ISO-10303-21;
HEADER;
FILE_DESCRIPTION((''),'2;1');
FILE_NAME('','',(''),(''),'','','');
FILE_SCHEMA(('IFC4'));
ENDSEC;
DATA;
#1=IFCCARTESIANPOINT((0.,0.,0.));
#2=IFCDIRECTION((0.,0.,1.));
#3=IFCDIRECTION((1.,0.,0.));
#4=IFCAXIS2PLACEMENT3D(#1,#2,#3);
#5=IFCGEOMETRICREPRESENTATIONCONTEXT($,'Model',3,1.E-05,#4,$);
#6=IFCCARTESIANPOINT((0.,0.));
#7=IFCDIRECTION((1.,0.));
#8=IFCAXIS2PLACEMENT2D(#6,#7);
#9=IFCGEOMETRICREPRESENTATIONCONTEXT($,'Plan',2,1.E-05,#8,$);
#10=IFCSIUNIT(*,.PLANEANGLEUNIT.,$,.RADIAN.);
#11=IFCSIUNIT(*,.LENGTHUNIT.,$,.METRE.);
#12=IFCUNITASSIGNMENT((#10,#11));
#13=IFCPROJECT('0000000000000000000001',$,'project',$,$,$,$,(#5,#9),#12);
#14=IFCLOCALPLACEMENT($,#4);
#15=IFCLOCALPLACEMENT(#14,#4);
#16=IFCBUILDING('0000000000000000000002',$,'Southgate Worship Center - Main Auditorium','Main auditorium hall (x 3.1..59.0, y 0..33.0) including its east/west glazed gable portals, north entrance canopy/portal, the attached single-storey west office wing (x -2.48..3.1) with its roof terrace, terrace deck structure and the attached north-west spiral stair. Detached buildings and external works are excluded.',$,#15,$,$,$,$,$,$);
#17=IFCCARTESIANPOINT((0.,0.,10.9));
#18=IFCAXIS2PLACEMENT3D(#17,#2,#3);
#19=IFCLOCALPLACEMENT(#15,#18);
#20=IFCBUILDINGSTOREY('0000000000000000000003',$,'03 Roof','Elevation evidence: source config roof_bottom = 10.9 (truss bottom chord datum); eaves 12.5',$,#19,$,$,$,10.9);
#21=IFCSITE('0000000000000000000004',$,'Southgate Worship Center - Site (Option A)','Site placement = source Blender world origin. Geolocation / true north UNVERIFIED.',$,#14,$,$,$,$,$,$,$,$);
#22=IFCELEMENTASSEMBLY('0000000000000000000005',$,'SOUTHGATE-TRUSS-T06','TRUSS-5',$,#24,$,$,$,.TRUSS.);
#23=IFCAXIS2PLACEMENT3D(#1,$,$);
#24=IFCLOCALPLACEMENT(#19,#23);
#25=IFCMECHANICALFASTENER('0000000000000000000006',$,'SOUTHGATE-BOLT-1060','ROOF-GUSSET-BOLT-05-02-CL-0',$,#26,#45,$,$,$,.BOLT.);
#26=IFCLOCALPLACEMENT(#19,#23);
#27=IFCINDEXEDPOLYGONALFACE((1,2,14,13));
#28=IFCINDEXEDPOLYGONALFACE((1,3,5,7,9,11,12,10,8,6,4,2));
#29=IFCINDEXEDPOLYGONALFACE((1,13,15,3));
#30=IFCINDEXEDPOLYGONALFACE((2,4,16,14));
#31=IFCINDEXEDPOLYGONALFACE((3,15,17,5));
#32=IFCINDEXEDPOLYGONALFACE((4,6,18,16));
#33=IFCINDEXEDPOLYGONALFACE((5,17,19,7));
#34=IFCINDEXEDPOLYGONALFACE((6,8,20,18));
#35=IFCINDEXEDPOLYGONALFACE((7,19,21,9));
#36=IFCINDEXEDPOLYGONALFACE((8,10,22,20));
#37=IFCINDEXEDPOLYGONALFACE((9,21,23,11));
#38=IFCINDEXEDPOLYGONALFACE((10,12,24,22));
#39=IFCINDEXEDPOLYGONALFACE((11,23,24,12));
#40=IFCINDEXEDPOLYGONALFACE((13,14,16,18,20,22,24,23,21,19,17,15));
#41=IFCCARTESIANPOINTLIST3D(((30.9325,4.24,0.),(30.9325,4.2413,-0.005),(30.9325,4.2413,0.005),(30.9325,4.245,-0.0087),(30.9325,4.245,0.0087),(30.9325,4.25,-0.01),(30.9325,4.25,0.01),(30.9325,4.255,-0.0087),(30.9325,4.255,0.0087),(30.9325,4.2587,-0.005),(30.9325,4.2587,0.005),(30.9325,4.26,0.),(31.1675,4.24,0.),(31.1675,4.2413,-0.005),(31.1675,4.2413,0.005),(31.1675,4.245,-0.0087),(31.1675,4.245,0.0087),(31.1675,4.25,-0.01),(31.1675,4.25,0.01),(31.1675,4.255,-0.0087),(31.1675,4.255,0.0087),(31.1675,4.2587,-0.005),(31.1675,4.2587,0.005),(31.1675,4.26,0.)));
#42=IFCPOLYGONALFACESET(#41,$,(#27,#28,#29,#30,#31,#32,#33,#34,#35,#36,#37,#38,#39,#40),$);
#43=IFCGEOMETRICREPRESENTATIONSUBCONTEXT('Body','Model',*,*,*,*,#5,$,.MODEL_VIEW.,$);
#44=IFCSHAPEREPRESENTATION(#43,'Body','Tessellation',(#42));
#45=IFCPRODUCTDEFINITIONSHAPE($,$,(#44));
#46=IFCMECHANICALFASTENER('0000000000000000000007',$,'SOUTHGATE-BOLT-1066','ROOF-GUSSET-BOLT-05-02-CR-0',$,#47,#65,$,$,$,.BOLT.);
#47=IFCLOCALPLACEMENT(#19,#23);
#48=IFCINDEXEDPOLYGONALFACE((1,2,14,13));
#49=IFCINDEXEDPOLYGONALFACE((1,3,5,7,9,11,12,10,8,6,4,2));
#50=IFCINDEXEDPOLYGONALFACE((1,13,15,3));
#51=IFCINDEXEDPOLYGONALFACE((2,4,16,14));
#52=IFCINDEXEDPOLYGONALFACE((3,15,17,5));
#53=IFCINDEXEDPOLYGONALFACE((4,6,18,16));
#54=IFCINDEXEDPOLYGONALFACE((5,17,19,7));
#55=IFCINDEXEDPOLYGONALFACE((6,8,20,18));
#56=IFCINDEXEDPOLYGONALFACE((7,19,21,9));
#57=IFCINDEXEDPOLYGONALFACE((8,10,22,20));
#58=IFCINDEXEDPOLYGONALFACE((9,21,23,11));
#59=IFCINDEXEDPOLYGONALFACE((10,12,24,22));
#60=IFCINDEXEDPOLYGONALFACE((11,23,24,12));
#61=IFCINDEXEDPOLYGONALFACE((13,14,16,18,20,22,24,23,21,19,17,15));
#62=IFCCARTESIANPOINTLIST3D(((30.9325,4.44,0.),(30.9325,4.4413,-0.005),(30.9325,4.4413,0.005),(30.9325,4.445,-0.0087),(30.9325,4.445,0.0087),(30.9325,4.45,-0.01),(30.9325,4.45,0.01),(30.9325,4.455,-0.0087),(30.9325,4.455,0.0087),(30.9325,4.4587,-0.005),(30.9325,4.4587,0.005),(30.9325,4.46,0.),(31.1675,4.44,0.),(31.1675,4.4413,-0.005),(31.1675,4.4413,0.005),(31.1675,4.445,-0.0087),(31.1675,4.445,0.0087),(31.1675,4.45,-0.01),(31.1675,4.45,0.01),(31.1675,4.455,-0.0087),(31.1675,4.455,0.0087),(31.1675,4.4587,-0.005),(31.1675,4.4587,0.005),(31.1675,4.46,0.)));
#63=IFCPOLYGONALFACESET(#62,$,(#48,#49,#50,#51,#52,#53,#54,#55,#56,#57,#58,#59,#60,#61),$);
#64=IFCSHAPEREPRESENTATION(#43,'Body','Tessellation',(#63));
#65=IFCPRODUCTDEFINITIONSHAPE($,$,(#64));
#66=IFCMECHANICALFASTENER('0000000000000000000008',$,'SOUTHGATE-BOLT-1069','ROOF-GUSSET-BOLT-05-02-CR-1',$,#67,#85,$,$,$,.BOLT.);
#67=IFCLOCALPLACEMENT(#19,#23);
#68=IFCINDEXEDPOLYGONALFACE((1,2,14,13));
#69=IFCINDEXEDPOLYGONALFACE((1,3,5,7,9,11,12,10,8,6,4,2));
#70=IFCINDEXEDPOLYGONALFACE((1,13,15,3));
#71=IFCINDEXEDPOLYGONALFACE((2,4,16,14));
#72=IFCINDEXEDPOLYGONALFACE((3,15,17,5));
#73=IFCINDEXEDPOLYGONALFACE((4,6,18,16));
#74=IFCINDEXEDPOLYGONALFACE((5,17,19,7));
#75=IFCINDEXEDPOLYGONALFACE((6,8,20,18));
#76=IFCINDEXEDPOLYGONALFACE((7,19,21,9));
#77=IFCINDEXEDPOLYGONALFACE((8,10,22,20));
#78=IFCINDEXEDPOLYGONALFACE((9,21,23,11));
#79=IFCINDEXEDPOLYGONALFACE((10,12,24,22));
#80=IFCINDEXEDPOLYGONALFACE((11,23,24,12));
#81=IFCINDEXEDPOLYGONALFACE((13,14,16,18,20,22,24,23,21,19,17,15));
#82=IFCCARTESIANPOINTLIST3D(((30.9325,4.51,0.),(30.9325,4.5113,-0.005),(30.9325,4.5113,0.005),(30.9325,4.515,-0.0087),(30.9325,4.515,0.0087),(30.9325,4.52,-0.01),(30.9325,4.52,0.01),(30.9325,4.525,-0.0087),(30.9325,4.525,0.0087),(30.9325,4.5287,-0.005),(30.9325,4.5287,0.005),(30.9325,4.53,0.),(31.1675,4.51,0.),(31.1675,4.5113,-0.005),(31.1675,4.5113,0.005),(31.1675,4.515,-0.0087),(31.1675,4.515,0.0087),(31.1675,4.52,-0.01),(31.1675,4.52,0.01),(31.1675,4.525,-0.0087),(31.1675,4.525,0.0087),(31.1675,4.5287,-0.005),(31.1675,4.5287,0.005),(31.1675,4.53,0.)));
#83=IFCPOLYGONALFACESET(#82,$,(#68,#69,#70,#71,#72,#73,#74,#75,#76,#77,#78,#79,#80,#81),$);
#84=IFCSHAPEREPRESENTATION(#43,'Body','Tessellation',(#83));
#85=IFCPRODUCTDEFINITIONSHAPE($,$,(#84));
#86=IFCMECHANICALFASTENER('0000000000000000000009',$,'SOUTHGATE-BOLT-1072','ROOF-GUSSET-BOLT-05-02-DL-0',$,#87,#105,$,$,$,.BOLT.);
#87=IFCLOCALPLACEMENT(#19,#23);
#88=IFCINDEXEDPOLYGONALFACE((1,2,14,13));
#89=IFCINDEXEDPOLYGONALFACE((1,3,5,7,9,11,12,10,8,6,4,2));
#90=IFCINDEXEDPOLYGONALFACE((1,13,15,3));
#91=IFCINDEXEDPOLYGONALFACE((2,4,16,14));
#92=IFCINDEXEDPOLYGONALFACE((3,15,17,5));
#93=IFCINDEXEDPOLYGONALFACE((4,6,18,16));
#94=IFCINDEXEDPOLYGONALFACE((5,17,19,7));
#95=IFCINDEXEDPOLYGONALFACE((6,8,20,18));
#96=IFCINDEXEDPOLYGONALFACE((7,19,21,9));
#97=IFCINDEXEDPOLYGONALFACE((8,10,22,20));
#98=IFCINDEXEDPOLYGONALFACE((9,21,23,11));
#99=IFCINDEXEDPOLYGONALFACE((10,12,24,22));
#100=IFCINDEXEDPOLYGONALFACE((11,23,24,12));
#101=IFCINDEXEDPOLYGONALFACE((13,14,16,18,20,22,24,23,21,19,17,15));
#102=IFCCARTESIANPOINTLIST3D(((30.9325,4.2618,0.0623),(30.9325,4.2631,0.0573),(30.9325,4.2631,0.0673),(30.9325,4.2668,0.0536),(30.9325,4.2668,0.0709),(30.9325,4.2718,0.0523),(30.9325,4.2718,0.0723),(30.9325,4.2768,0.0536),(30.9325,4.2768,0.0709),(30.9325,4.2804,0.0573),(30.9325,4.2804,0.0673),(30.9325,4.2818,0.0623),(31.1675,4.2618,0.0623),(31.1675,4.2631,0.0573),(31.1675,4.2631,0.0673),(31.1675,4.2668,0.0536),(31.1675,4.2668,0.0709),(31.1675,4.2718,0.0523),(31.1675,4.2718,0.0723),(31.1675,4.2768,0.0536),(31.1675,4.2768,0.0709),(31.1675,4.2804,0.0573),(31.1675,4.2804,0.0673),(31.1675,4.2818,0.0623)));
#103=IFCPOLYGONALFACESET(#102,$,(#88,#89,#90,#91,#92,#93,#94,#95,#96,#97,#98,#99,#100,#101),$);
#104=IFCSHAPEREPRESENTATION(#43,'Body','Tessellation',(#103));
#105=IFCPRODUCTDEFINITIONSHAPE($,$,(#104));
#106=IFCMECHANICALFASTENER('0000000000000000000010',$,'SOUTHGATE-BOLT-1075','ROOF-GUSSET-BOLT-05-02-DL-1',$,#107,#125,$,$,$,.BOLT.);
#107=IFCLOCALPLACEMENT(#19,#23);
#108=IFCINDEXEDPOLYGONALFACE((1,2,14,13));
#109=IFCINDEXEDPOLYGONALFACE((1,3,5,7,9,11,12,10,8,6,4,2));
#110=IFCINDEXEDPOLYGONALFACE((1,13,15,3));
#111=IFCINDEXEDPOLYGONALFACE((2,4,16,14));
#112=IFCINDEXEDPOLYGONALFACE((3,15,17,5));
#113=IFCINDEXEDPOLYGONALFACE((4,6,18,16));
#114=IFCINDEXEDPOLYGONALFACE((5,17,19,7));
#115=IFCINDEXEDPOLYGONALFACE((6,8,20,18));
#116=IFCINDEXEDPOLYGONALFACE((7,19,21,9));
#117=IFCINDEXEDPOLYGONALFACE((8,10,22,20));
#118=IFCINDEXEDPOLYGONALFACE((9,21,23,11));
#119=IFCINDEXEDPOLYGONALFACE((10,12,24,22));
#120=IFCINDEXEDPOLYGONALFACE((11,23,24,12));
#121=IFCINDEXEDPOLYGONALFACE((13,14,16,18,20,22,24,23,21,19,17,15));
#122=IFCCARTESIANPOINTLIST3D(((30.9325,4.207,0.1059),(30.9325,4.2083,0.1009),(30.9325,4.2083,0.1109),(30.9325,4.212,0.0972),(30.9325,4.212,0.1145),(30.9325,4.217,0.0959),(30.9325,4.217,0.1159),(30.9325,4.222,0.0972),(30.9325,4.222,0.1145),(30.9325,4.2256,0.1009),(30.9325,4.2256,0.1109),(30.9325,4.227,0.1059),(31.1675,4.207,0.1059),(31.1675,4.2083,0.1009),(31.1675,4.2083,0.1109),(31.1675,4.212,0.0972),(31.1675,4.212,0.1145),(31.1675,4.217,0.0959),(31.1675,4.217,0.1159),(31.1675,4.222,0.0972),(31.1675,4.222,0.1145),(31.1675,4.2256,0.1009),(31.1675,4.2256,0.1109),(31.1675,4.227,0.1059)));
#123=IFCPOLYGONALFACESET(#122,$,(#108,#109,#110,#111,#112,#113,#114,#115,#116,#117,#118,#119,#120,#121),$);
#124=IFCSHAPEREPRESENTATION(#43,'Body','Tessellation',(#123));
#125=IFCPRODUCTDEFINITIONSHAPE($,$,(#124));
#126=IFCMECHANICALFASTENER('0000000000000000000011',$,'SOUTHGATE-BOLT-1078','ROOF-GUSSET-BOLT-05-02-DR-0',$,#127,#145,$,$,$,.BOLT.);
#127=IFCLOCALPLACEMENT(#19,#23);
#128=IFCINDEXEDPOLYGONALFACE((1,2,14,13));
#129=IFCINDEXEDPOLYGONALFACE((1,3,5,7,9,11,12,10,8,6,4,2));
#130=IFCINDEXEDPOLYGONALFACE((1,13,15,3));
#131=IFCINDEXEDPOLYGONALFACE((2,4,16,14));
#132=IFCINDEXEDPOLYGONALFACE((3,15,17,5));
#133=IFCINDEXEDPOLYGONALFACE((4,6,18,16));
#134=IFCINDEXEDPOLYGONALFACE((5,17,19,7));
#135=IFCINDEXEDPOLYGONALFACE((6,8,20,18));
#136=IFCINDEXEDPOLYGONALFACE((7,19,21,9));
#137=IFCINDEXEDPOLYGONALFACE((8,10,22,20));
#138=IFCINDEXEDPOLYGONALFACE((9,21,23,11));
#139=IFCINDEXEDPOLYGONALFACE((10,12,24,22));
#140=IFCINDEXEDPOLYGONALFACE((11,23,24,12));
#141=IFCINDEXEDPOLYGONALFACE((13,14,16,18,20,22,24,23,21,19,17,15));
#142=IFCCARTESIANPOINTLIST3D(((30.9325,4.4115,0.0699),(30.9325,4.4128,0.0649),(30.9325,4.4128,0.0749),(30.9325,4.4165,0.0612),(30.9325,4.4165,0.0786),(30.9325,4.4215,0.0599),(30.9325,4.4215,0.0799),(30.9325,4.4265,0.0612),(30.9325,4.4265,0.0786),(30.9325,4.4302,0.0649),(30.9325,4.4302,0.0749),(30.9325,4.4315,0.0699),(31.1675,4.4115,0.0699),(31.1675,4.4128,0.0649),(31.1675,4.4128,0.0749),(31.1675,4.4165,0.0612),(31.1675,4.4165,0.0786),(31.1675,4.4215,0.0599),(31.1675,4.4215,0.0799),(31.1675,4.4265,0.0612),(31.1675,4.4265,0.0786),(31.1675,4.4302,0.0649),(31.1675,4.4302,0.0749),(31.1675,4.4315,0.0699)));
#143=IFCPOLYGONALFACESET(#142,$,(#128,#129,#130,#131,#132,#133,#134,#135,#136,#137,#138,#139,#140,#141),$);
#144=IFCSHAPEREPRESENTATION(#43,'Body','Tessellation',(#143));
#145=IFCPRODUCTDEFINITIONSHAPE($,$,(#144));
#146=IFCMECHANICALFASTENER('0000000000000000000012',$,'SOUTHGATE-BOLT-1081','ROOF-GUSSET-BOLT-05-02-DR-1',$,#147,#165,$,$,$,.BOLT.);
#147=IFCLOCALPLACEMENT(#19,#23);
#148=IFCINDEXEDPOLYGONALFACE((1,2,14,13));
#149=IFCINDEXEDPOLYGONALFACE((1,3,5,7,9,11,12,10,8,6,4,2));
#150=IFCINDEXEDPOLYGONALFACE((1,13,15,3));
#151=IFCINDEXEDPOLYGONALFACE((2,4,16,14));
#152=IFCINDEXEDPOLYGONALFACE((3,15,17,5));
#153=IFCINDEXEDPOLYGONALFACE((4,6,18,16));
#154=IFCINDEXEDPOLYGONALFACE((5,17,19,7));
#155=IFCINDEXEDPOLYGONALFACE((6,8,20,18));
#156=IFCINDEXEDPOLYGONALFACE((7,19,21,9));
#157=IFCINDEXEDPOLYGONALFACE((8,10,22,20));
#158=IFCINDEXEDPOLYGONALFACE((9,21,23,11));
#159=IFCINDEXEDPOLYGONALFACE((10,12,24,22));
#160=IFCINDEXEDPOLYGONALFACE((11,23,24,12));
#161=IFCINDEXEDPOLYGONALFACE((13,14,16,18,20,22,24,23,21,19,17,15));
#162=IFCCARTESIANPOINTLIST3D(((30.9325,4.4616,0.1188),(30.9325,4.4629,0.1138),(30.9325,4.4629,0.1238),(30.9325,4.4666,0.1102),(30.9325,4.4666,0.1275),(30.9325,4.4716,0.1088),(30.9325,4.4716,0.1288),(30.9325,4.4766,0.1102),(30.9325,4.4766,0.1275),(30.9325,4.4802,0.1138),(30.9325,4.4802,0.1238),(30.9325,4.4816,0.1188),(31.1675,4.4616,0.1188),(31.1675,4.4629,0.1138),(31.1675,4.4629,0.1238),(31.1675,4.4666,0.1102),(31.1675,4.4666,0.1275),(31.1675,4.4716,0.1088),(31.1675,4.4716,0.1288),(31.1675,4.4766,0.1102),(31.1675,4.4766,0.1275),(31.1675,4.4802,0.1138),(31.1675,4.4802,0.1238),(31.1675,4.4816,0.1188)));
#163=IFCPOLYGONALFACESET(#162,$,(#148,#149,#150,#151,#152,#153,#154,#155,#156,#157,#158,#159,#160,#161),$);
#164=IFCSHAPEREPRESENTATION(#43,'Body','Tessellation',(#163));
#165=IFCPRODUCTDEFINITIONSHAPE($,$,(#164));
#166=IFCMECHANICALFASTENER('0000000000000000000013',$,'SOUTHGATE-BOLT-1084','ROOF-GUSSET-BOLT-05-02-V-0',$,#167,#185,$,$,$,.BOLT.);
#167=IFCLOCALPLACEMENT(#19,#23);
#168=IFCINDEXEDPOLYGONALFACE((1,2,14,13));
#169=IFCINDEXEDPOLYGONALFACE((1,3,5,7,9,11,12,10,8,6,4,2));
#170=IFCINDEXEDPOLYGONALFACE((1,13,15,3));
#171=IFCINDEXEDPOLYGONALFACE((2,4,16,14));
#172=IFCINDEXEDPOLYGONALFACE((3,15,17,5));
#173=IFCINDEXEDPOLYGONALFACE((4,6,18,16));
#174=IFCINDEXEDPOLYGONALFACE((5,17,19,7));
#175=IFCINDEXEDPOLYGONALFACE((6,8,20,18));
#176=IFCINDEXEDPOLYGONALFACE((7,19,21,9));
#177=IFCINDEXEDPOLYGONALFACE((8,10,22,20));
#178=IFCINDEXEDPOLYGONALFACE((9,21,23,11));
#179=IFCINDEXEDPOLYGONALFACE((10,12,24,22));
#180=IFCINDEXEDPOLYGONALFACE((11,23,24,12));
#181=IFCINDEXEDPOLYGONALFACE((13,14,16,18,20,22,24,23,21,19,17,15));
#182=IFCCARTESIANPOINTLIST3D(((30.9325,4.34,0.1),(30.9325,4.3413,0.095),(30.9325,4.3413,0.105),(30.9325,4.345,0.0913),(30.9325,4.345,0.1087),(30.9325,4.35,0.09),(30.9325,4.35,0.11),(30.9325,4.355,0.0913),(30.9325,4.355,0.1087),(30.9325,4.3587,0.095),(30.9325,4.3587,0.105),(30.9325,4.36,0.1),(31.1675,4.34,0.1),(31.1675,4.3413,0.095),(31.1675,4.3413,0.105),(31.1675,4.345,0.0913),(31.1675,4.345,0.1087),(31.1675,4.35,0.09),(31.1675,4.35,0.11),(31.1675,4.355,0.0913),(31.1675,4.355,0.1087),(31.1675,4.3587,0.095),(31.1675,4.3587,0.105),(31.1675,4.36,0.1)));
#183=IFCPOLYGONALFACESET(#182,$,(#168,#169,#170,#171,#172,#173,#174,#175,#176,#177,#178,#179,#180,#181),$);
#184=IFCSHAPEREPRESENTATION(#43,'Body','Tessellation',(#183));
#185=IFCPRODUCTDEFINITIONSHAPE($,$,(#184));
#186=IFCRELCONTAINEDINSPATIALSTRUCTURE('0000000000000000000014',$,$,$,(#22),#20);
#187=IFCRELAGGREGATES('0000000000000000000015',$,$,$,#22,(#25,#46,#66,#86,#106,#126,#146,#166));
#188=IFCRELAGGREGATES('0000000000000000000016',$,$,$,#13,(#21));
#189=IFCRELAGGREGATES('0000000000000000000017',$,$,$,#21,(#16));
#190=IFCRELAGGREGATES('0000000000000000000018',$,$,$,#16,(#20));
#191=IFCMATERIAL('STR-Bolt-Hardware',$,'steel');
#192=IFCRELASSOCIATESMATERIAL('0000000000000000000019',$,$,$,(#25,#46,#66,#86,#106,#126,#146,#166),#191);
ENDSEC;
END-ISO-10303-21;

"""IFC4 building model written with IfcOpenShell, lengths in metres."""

from ifc_helpers import new_model, si_unit, frame, origin_with_axes, origin_2d_with_axis, place, context, subcontext, project, spatial, indexed_curve, outline, extrude, material, element, aggregate, save


model = new_model("IFC4")

# Units and contexts
model_context = context("Model", 3, precision=1e-05, world=origin_with_axes())
plan_context = context("Plan", 2, precision=1e-05, world=origin_2d_with_axis())
body_context = subcontext(model_context, "Body", "Model", "MODEL_VIEW")
ifc_project = project(units=[si_unit("PLANEANGLEUNIT", "RADIAN"), si_unit("LENGTHUNIT", "METRE")], contexts=[model_context, plan_context])

# Site, building, storey
site_placement = place(None, origin_with_axes())
site = spatial("IfcSite", under=ifc_project, at=site_placement, Name="Southgate Worship Center - Site (Option A)", Description="Site placement = source Blender world origin. Geolocation / true north UNVERIFIED.")
building_placement = place(site_placement, origin_with_axes())
building = spatial("IfcBuilding", under=site, at=building_placement, Name="Southgate Worship Center - Main Auditorium", Description="Main auditorium hall (x 3.1..59.0, y 0..33.0) including its east/west glazed gable portals, north entrance canopy/portal, the attached single-storey west office wing (x -2.48..3.1) with its roof terrace, terrace deck structure and the attached north-west spiral stair. Detached buildings and external works are excluded.")
storey_placement = place(building_placement, frame((0.0, 0.0, 10.9), z_axis=(0.0, 0.0, 1.0), x_axis=(1.0, 0.0, 0.0)))
storey = spatial("IfcBuildingStorey", under=building, at=storey_placement, Name="03 Roof", Description="Elevation evidence: source config roof_bottom = 10.9 (truss bottom chord datum); eaves 12.5", Elevation=10.9)

# Element assembly, mechanical fasteners
assembly_placement = place(storey_placement, origin_with_axes())
assembly = element("IfcElementAssembly", 1, at=assembly_placement, inside=storey, Name="SOUTHGATE-TRUSS-T06", Description="TRUSS-5", PredefinedType="TRUSS")
ifc_material = material(Name="STR-Bolt-Hardware", Category="steel")
mechanical_fastener_1_placement = place(assembly_placement, frame((30.9325, 4.24, -0.01), z_axis=(0.0, 0.0, 1.0), x_axis=(1.0, 0.0, 0.0)))
mechanical_fastener_1 = element("IfcMechanicalFastener", 2, at=mechanical_fastener_1_placement, material=ifc_material, Name="SOUTHGATE-BOLT-1060", Description="ROOF-GUSSET-BOLT-05-02-CL-0", PredefinedType="BOLT", context=body_context, shape_type="SweptSolid", body=[
    extrude(outline(indexed_curve([(0.0, 0.0), (0.0013, -0.005), (0.005, -0.0087), (0.01, -0.01), (0.015, -0.0087), (0.0187, -0.005), (0.02, 0.0), (0.0187, 0.005), (0.015, 0.0087), (0.01, 0.01), (0.005, 0.0087), (0.0013, 0.005), (0.0, 0.0)], self_intersect=False)), frame((0.0, 0.0, 0.01), z_axis=(1.0, 0.0, 0.0), x_axis=(0.0, 1.0, 0.0)), (0.0, 0.0, 1.0), 0.235),
])
mechanical_fastener_2_placement = place(assembly_placement, frame((30.9325, 4.44, -0.01), z_axis=(0.0, 0.0, 1.0), x_axis=(1.0, 0.0, 0.0)))
mechanical_fastener_2 = element("IfcMechanicalFastener", 3, at=mechanical_fastener_2_placement, material=ifc_material, Name="SOUTHGATE-BOLT-1066", Description="ROOF-GUSSET-BOLT-05-02-CR-0", PredefinedType="BOLT", context=body_context, shape_type="SweptSolid", body=[
    extrude(outline(indexed_curve([(0.0, 0.0), (0.0013, -0.005), (0.005, -0.0087), (0.01, -0.01), (0.015, -0.0087), (0.0187, -0.005), (0.02, 0.0), (0.0187, 0.005), (0.015, 0.0087), (0.01, 0.01), (0.005, 0.0087), (0.0013, 0.005), (0.0, 0.0)], self_intersect=False)), frame((0.0, 0.0, 0.01), z_axis=(1.0, 0.0, 0.0), x_axis=(0.0, 1.0, 0.0)), (0.0, 0.0, 1.0), 0.235),
])
mechanical_fastener_3_placement = place(assembly_placement, frame((30.9325, 4.51, -0.01), z_axis=(0.0, 0.0, 1.0), x_axis=(1.0, 0.0, 0.0)))
mechanical_fastener_3 = element("IfcMechanicalFastener", 4, at=mechanical_fastener_3_placement, material=ifc_material, Name="SOUTHGATE-BOLT-1069", Description="ROOF-GUSSET-BOLT-05-02-CR-1", PredefinedType="BOLT", context=body_context, shape_type="SweptSolid", body=[
    extrude(outline(indexed_curve([(0.0, 0.0), (0.0013, -0.005), (0.005, -0.0087), (0.01, -0.01), (0.015, -0.0087), (0.0187, -0.005), (0.02, 0.0), (0.0187, 0.005), (0.015, 0.0087), (0.01, 0.01), (0.005, 0.0087), (0.0013, 0.005), (0.0, 0.0)], self_intersect=False)), frame((0.0, 0.0, 0.01), z_axis=(1.0, 0.0, 0.0), x_axis=(0.0, 1.0, 0.0)), (0.0, 0.0, 1.0), 0.235),
])
mechanical_fastener_4_placement = place(assembly_placement, frame((30.9325, 4.2618, 0.0523), z_axis=(0.0, 0.0, 1.0), x_axis=(1.0, 0.0, 0.0)))
mechanical_fastener_4 = element("IfcMechanicalFastener", 5, at=mechanical_fastener_4_placement, material=ifc_material, Name="SOUTHGATE-BOLT-1072", Description="ROOF-GUSSET-BOLT-05-02-DL-0", PredefinedType="BOLT", context=body_context, shape_type="SweptSolid", body=[
    extrude(outline(indexed_curve([(0.0, 0.0), (0.0013, -0.005), (0.005, -0.0087), (0.01, -0.01), (0.015, -0.0087), (0.0187, -0.005), (0.02, 0.0), (0.0187, 0.005), (0.015, 0.0087), (0.01, 0.01), (0.005, 0.0087), (0.0013, 0.005), (0.0, 0.0)], self_intersect=False)), frame((0.0, 0.0, 0.01), z_axis=(1.0, 0.0, 0.0), x_axis=(0.0, 1.0, 0.0)), (0.0, 0.0, 1.0), 0.235),
])
mechanical_fastener_5_placement = place(assembly_placement, frame((30.9325, 4.207, 0.0959), z_axis=(0.0, 0.0, 1.0), x_axis=(1.0, 0.0, 0.0)))
mechanical_fastener_5 = element("IfcMechanicalFastener", 6, at=mechanical_fastener_5_placement, material=ifc_material, Name="SOUTHGATE-BOLT-1075", Description="ROOF-GUSSET-BOLT-05-02-DL-1", PredefinedType="BOLT", context=body_context, shape_type="SweptSolid", body=[
    extrude(outline(indexed_curve([(0.0, 0.0), (0.0013, -0.005), (0.005, -0.0087), (0.01, -0.01), (0.015, -0.0087), (0.0187, -0.005), (0.02, 0.0), (0.0187, 0.005), (0.015, 0.0087), (0.01, 0.01), (0.005, 0.0087), (0.0013, 0.005), (0.0, 0.0)], self_intersect=False)), frame((0.0, 0.0, 0.01), z_axis=(1.0, 0.0, 0.0), x_axis=(0.0, 1.0, 0.0)), (0.0, 0.0, 1.0), 0.235),
])
mechanical_fastener_6_placement = place(assembly_placement, frame((30.9325, 4.4115, 0.0599), z_axis=(0.0, 0.0, 1.0), x_axis=(1.0, 0.0, 0.0)))
mechanical_fastener_6 = element("IfcMechanicalFastener", 7, at=mechanical_fastener_6_placement, material=ifc_material, Name="SOUTHGATE-BOLT-1078", Description="ROOF-GUSSET-BOLT-05-02-DR-0", PredefinedType="BOLT", context=body_context, shape_type="SweptSolid", body=[
    extrude(outline(indexed_curve([(0.0, 0.0), (0.0013, -0.005), (0.005, -0.0087), (0.01, -0.01), (0.015, -0.0087), (0.0187, -0.005), (0.02, 0.0), (0.0187, 0.005), (0.015, 0.0087), (0.01, 0.01), (0.005, 0.0087), (0.0013, 0.005), (0.0, 0.0)], self_intersect=False)), frame((0.0, 0.0, 0.01), z_axis=(1.0, 0.0, 0.0), x_axis=(0.0, 1.0, 0.0)), (0.0, 0.0, 1.0), 0.235),
])
mechanical_fastener_7_placement = place(assembly_placement, frame((30.9325, 4.4616, 0.1088), z_axis=(0.0, 0.0, 1.0), x_axis=(1.0, 0.0, 0.0)))
mechanical_fastener_7 = element("IfcMechanicalFastener", 8, at=mechanical_fastener_7_placement, material=ifc_material, Name="SOUTHGATE-BOLT-1081", Description="ROOF-GUSSET-BOLT-05-02-DR-1", PredefinedType="BOLT", context=body_context, shape_type="SweptSolid", body=[
    extrude(outline(indexed_curve([(0.0, 0.0), (0.0013, -0.005), (0.005, -0.0087), (0.01, -0.01), (0.015, -0.0087), (0.0187, -0.005), (0.02, 0.0), (0.0187, 0.005), (0.015, 0.0087), (0.01, 0.01), (0.005, 0.0087), (0.0013, 0.005), (0.0, 0.0)], self_intersect=False)), frame((0.0, 0.0, 0.01), z_axis=(1.0, 0.0, 0.0), x_axis=(0.0, 1.0, 0.0)), (0.0, 0.0, 1.0), 0.235),
])
mechanical_fastener_8_placement = place(assembly_placement, frame((30.9325, 4.34, 0.09), z_axis=(0.0, 0.0, 1.0), x_axis=(1.0, 0.0, 0.0)))
mechanical_fastener_8 = element("IfcMechanicalFastener", 9, at=mechanical_fastener_8_placement, material=ifc_material, Name="SOUTHGATE-BOLT-1084", Description="ROOF-GUSSET-BOLT-05-02-V-0", PredefinedType="BOLT", context=body_context, shape_type="SweptSolid", body=[
    extrude(outline(indexed_curve([(0.0, 0.0), (0.0013, -0.005), (0.005, -0.0087), (0.01, -0.01), (0.015, -0.0087), (0.0187, -0.005), (0.02, 0.0), (0.0187, 0.005), (0.015, 0.0087), (0.01, 0.01), (0.005, 0.0087), (0.0013, 0.005), (0.0, 0.0)], self_intersect=False)), frame((0.0, 0.0, 0.01), z_axis=(1.0, 0.0, 0.0), x_axis=(0.0, 1.0, 0.0)), (0.0, 0.0, 1.0), 0.235),
])
aggregate(assembly, [mechanical_fastener_1, mechanical_fastener_2, mechanical_fastener_3, mechanical_fastener_4, mechanical_fastener_5, mechanical_fastener_6, mechanical_fastener_7, mechanical_fastener_8])

save(model, "model.ifc")
